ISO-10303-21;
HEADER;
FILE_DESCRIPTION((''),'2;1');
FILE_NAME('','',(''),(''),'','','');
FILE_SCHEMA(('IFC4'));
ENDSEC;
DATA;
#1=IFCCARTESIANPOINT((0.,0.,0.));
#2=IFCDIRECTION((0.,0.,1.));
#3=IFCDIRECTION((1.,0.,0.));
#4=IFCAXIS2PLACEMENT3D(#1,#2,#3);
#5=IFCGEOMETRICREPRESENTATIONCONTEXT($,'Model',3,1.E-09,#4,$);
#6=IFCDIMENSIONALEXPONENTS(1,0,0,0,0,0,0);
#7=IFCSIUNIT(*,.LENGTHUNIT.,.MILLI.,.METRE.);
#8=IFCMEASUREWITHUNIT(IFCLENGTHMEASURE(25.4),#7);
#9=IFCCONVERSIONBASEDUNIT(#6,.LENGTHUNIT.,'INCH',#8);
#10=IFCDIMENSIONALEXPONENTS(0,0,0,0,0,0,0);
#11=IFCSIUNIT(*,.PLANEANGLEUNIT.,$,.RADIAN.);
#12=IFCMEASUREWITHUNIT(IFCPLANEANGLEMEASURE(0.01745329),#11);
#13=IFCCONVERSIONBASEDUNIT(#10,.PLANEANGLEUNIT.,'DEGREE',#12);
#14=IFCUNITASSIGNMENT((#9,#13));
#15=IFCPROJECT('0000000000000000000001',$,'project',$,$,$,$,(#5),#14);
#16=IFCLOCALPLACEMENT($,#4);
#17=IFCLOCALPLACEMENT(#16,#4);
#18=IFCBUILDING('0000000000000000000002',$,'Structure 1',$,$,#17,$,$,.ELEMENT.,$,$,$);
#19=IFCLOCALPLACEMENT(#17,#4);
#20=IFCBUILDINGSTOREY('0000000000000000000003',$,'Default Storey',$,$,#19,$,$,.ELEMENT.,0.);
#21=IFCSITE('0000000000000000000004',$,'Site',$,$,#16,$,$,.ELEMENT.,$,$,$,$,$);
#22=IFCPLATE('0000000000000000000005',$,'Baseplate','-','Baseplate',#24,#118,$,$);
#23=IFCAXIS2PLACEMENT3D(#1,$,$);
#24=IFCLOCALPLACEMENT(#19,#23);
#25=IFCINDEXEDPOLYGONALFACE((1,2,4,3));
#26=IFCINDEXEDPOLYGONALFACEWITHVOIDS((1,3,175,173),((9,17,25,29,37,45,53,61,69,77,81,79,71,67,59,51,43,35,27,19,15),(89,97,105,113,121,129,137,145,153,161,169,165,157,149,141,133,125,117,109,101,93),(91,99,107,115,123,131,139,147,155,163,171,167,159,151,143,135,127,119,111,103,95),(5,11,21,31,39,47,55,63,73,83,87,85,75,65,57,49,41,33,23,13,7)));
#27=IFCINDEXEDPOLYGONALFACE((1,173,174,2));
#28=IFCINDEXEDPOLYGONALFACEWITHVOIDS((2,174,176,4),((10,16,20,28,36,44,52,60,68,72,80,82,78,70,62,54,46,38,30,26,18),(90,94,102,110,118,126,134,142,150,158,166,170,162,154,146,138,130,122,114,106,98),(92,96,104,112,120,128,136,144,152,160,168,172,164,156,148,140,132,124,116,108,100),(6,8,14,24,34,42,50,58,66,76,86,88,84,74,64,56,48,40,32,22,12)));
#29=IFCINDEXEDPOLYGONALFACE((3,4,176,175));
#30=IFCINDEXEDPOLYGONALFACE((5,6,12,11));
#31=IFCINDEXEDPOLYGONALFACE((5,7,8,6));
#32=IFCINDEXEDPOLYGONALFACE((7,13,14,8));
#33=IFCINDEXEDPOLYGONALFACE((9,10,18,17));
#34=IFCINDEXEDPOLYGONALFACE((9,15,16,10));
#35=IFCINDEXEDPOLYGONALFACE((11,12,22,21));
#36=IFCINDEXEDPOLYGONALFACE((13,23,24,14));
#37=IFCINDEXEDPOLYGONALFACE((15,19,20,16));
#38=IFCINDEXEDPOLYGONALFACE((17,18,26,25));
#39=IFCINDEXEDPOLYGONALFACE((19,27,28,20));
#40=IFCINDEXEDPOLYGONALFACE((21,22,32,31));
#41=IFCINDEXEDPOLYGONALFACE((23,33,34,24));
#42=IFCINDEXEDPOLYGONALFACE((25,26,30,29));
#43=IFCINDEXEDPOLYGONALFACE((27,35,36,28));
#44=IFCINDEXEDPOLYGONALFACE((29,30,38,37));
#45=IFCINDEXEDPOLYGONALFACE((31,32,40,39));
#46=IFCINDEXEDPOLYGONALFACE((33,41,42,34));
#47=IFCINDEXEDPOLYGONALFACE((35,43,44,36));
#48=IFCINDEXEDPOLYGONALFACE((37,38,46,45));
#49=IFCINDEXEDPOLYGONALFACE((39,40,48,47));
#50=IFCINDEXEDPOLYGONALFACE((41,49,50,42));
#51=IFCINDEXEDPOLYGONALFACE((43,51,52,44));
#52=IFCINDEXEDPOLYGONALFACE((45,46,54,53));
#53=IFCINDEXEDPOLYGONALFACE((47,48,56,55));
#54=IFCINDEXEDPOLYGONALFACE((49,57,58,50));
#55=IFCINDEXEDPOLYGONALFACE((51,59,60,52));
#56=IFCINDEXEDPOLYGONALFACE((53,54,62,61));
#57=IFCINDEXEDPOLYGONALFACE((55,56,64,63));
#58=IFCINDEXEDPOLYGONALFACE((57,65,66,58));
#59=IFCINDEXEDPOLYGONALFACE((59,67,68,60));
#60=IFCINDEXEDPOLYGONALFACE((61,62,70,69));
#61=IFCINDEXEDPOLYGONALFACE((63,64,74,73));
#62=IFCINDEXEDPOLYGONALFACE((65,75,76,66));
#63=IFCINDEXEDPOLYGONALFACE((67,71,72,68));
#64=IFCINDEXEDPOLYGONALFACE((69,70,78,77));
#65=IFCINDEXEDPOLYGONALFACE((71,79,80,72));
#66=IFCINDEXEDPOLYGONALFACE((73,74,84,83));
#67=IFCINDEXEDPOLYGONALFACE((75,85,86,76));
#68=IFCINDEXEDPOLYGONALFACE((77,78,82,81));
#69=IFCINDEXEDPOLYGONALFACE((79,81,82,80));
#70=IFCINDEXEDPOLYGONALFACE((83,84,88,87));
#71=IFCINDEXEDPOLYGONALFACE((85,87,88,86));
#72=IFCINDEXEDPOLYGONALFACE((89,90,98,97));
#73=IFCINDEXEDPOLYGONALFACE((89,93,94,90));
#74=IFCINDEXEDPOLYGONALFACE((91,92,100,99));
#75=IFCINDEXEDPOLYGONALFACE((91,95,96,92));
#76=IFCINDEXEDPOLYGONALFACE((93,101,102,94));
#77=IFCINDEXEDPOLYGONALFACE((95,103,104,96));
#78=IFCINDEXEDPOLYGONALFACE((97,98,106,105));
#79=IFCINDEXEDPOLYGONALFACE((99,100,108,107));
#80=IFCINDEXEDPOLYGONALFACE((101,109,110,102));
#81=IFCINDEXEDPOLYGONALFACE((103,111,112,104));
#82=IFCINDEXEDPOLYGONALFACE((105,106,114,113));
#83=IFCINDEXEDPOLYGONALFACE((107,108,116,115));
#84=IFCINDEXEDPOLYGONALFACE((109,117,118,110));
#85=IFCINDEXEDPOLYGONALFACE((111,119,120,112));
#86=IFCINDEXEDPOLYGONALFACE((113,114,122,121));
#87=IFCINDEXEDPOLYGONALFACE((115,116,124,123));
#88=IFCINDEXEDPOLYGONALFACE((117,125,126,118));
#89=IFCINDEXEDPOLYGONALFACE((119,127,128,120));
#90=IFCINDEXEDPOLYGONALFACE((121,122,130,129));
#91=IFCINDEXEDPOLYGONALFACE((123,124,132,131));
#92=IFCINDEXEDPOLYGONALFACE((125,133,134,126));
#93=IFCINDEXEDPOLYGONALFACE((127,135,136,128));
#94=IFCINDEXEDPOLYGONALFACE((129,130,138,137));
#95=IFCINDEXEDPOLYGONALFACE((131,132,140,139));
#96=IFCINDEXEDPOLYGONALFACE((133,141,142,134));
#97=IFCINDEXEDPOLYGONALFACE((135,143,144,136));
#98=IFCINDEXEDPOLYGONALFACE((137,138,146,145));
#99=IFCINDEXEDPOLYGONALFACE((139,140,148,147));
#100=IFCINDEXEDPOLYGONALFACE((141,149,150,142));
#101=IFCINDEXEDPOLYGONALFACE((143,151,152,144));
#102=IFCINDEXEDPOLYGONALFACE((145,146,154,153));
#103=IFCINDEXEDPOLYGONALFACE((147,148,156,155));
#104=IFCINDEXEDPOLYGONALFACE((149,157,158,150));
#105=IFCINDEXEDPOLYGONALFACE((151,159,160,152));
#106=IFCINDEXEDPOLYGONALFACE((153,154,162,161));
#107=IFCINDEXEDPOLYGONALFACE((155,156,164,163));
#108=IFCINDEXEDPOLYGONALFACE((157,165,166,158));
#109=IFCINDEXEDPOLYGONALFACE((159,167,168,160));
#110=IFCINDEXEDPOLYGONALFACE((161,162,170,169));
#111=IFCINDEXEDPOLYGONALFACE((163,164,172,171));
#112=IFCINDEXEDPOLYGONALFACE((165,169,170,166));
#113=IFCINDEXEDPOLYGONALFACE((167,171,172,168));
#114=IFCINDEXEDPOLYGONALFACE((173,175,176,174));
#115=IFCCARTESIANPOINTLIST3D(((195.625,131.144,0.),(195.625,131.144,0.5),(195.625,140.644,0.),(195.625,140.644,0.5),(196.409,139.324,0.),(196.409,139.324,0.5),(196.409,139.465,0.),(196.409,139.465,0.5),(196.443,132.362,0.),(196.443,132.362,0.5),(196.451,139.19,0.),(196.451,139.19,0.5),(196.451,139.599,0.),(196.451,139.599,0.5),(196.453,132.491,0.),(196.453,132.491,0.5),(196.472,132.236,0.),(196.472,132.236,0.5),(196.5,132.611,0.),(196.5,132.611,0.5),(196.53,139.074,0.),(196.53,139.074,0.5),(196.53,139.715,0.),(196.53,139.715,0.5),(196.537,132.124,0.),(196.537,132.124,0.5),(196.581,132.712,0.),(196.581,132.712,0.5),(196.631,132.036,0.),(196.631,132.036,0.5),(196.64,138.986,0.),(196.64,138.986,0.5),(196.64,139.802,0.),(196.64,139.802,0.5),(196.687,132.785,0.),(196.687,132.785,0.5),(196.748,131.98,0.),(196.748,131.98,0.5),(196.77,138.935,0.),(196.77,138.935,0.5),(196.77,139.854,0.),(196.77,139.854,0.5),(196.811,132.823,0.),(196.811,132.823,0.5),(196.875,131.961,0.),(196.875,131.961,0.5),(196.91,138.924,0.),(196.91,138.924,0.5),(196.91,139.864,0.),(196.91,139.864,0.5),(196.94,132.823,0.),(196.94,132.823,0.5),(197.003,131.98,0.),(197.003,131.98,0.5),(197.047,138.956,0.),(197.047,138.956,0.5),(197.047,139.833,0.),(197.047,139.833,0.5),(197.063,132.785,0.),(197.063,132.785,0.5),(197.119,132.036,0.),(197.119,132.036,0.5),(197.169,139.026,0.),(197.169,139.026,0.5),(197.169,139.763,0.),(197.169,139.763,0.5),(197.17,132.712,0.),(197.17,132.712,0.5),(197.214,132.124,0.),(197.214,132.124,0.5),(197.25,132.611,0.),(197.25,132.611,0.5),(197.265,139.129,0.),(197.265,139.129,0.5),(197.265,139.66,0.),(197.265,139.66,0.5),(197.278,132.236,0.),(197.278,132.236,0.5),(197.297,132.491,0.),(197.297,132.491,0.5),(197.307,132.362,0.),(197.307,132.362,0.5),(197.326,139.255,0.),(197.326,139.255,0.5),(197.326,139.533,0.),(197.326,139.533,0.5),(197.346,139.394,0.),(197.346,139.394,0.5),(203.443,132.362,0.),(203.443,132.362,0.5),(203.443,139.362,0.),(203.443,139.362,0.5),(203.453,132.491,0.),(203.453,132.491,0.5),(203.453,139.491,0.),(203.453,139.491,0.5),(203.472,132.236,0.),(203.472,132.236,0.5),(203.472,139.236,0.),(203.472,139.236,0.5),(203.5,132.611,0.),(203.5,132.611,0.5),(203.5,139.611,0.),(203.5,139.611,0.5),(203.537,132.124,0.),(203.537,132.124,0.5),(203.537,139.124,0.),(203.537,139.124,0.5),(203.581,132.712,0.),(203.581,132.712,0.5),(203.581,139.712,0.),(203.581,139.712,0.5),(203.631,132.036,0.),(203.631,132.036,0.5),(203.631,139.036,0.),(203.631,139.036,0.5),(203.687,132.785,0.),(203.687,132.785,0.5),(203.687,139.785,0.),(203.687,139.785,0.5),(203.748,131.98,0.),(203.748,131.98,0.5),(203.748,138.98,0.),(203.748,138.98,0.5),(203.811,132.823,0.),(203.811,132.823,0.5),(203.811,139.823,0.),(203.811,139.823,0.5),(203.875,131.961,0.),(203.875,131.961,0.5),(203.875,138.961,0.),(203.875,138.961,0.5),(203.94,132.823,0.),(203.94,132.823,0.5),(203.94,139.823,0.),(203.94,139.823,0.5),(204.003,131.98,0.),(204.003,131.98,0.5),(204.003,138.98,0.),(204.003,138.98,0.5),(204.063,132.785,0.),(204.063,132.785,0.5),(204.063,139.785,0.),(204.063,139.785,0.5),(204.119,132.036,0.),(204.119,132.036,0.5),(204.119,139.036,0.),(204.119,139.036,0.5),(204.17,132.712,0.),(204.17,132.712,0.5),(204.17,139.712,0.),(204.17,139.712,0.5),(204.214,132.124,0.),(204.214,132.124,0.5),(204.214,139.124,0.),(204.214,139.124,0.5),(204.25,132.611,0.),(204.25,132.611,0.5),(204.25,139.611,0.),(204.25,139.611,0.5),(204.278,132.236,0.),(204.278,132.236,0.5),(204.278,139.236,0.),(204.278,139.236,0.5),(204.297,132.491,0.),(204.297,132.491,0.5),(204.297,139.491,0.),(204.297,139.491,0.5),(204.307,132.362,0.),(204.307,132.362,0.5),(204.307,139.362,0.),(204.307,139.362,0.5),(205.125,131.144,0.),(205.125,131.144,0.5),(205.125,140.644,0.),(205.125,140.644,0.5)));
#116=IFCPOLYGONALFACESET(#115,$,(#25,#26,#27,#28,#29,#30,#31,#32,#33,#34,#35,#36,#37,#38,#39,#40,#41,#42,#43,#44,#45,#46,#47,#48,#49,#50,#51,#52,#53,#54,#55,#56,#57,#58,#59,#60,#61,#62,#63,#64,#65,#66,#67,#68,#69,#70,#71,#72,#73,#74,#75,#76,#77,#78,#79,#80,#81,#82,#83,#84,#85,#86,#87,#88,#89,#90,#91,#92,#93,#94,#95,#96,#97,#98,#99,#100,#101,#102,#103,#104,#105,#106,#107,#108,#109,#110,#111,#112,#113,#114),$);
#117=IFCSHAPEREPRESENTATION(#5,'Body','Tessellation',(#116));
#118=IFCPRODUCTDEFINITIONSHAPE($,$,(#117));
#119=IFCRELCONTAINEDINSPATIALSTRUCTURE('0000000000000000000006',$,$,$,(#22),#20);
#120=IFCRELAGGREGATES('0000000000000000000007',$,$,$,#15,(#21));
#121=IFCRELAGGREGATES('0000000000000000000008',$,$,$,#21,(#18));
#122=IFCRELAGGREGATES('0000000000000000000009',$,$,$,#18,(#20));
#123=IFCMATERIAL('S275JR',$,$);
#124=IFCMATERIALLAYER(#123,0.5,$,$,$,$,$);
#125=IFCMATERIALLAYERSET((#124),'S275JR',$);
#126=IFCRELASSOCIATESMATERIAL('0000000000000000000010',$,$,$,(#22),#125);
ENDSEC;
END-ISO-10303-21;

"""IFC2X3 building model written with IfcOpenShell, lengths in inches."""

from ifc_helpers import new_model, entity, si_unit, converted_unit, frame, frame_2d, origin, origin_with_axes, origin_2d_with_axis, place, context, project, spatial, polyline, circle, outline, extrude, material, layer, layer_set, element, save


model = new_model("IFC2X3")

# Units and contexts
model_context = context("Model", 3, precision=1e-09, world=origin_with_axes())
ifc_project = project(units=[converted_unit("LENGTHUNIT", "INCH", entity("IfcLengthMeasure", 25.4), si_unit("LENGTHUNIT", "METRE", prefix="MILLI"), dimensions=[1, 0, 0, 0, 0, 0, 0]), converted_unit("PLANEANGLEUNIT", "DEGREE", entity("IfcPlaneAngleMeasure", 0.01745329), si_unit("PLANEANGLEUNIT", "RADIAN"), dimensions=[0, 0, 0, 0, 0, 0, 0])], contexts=[model_context])

# Site, building, storey
site_placement = place(None, origin_with_axes())
site = spatial("IfcSite", under=ifc_project, at=site_placement, Name="Site", CompositionType="ELEMENT")
building_placement = place(site_placement, origin_with_axes())
building = spatial("IfcBuilding", under=site, at=building_placement, Name="Structure 1", CompositionType="ELEMENT")
storey_placement = place(building_placement, origin_with_axes())
storey = spatial("IfcBuildingStorey", under=building, at=storey_placement, Name="Default Storey", CompositionType="ELEMENT", Elevation=0.0)

# Plate, openings
ifc_material_1 = material(Name="S275JR")
ifc_layer_1 = layer(ifc_material_1, 0.5)
ifc_layer_set_1 = layer_set([ifc_layer_1], Name="S275JR")
plate_1_placement = place(None, frame((205.125, 140.644, 0.5), z_axis=(0.0, 0.0, -1.0), x_axis=(0.0, -1.0, 0.0)))
plate_1 = element("IfcPlate", 1, at=plate_1_placement, inside=storey, material=ifc_layer_set_1, Name="Baseplate", Description="-", ObjectType="Baseplate", context=model_context, shape_type="SweptSolid", body=[
    extrude(outline(polyline([(0.0, 0.0), (9.5, 0.0), (9.5, 9.5), (0.0, 9.5), (0.0, 0.0)])), origin_with_axes(), (0.0, 0.0, 1.0), 0.5),
])
opening_1_placement = place(plate_1_placement, frame((1.25, 8.25, 0.52), z_axis=(0.0, 0.0, -1.0), x_axis=(1.0, 0.0, 0.0)))
element("IfcOpeningElement", 2, at=opening_1_placement, cuts=plate_1, ObjectType="Opening", context=model_context, shape_type="SweptSolid", body=[
    extrude(circle(Radius=0.433, at=frame_2d((7.0, 7.0), x_axis=(1.0, 0.0))), origin(), (0.0, 0.0, 1.0), 0.539),
])
opening_2_placement = place(plate_1_placement, frame((1.25, 8.25, 0.52), z_axis=(0.0, 0.0, -1.0), x_axis=(1.0, 0.0, 0.0)))
element("IfcOpeningElement", 3, at=opening_2_placement, cuts=plate_1, ObjectType="Opening", context=model_context, shape_type="SweptSolid", body=[
    extrude(circle(Radius=0.433, at=frame_2d((0.0, 7.0), x_axis=(1.0, 0.0))), origin(), (0.0, 0.0, 1.0), 0.539),
])
opening_3_placement = place(plate_1_placement, frame((1.25, 8.25, 0.52), z_axis=(0.0, 0.0, -1.0), x_axis=(1.0, 0.0, 0.0)))
element("IfcOpeningElement", 4, at=opening_3_placement, cuts=plate_1, ObjectType="Opening", context=model_context, shape_type="SweptSolid", body=[
    extrude(circle(Radius=0.433, at=frame_2d((7.0, 0.0), x_axis=(1.0, 0.0))), origin(), (0.0, 0.0, 1.0), 0.539),
])
opening_4_placement = place(plate_1_placement, frame((1.25, 8.25, 0.52), z_axis=(0.0, 0.0, -1.0), x_axis=(1.0, 0.0, 0.0)))
element("IfcOpeningElement", 5, at=opening_4_placement, cuts=plate_1, ObjectType="Opening", context=model_context, shape_type="SweptSolid", body=[
    extrude(circle(Radius=0.433, at=origin_2d_with_axis()), origin(), (0.0, 0.0, 1.0), 0.539),
])
opening_5_placement = place(plate_1_placement, frame((1.25, 8.25, 0.52), z_axis=(0.0, 0.0, -1.0), x_axis=(0.0, -1.0, 0.0)))
element("IfcOpeningElement", 6, at=opening_5_placement, cuts=plate_1, ObjectType="Opening", context=model_context, shape_type="SweptSolid", body=[
    extrude(circle(Radius=0.471, at=origin_2d_with_axis()), origin(), (0.0, 0.0, 1.0), 0.539),
])

save(model, "model.ifc")
